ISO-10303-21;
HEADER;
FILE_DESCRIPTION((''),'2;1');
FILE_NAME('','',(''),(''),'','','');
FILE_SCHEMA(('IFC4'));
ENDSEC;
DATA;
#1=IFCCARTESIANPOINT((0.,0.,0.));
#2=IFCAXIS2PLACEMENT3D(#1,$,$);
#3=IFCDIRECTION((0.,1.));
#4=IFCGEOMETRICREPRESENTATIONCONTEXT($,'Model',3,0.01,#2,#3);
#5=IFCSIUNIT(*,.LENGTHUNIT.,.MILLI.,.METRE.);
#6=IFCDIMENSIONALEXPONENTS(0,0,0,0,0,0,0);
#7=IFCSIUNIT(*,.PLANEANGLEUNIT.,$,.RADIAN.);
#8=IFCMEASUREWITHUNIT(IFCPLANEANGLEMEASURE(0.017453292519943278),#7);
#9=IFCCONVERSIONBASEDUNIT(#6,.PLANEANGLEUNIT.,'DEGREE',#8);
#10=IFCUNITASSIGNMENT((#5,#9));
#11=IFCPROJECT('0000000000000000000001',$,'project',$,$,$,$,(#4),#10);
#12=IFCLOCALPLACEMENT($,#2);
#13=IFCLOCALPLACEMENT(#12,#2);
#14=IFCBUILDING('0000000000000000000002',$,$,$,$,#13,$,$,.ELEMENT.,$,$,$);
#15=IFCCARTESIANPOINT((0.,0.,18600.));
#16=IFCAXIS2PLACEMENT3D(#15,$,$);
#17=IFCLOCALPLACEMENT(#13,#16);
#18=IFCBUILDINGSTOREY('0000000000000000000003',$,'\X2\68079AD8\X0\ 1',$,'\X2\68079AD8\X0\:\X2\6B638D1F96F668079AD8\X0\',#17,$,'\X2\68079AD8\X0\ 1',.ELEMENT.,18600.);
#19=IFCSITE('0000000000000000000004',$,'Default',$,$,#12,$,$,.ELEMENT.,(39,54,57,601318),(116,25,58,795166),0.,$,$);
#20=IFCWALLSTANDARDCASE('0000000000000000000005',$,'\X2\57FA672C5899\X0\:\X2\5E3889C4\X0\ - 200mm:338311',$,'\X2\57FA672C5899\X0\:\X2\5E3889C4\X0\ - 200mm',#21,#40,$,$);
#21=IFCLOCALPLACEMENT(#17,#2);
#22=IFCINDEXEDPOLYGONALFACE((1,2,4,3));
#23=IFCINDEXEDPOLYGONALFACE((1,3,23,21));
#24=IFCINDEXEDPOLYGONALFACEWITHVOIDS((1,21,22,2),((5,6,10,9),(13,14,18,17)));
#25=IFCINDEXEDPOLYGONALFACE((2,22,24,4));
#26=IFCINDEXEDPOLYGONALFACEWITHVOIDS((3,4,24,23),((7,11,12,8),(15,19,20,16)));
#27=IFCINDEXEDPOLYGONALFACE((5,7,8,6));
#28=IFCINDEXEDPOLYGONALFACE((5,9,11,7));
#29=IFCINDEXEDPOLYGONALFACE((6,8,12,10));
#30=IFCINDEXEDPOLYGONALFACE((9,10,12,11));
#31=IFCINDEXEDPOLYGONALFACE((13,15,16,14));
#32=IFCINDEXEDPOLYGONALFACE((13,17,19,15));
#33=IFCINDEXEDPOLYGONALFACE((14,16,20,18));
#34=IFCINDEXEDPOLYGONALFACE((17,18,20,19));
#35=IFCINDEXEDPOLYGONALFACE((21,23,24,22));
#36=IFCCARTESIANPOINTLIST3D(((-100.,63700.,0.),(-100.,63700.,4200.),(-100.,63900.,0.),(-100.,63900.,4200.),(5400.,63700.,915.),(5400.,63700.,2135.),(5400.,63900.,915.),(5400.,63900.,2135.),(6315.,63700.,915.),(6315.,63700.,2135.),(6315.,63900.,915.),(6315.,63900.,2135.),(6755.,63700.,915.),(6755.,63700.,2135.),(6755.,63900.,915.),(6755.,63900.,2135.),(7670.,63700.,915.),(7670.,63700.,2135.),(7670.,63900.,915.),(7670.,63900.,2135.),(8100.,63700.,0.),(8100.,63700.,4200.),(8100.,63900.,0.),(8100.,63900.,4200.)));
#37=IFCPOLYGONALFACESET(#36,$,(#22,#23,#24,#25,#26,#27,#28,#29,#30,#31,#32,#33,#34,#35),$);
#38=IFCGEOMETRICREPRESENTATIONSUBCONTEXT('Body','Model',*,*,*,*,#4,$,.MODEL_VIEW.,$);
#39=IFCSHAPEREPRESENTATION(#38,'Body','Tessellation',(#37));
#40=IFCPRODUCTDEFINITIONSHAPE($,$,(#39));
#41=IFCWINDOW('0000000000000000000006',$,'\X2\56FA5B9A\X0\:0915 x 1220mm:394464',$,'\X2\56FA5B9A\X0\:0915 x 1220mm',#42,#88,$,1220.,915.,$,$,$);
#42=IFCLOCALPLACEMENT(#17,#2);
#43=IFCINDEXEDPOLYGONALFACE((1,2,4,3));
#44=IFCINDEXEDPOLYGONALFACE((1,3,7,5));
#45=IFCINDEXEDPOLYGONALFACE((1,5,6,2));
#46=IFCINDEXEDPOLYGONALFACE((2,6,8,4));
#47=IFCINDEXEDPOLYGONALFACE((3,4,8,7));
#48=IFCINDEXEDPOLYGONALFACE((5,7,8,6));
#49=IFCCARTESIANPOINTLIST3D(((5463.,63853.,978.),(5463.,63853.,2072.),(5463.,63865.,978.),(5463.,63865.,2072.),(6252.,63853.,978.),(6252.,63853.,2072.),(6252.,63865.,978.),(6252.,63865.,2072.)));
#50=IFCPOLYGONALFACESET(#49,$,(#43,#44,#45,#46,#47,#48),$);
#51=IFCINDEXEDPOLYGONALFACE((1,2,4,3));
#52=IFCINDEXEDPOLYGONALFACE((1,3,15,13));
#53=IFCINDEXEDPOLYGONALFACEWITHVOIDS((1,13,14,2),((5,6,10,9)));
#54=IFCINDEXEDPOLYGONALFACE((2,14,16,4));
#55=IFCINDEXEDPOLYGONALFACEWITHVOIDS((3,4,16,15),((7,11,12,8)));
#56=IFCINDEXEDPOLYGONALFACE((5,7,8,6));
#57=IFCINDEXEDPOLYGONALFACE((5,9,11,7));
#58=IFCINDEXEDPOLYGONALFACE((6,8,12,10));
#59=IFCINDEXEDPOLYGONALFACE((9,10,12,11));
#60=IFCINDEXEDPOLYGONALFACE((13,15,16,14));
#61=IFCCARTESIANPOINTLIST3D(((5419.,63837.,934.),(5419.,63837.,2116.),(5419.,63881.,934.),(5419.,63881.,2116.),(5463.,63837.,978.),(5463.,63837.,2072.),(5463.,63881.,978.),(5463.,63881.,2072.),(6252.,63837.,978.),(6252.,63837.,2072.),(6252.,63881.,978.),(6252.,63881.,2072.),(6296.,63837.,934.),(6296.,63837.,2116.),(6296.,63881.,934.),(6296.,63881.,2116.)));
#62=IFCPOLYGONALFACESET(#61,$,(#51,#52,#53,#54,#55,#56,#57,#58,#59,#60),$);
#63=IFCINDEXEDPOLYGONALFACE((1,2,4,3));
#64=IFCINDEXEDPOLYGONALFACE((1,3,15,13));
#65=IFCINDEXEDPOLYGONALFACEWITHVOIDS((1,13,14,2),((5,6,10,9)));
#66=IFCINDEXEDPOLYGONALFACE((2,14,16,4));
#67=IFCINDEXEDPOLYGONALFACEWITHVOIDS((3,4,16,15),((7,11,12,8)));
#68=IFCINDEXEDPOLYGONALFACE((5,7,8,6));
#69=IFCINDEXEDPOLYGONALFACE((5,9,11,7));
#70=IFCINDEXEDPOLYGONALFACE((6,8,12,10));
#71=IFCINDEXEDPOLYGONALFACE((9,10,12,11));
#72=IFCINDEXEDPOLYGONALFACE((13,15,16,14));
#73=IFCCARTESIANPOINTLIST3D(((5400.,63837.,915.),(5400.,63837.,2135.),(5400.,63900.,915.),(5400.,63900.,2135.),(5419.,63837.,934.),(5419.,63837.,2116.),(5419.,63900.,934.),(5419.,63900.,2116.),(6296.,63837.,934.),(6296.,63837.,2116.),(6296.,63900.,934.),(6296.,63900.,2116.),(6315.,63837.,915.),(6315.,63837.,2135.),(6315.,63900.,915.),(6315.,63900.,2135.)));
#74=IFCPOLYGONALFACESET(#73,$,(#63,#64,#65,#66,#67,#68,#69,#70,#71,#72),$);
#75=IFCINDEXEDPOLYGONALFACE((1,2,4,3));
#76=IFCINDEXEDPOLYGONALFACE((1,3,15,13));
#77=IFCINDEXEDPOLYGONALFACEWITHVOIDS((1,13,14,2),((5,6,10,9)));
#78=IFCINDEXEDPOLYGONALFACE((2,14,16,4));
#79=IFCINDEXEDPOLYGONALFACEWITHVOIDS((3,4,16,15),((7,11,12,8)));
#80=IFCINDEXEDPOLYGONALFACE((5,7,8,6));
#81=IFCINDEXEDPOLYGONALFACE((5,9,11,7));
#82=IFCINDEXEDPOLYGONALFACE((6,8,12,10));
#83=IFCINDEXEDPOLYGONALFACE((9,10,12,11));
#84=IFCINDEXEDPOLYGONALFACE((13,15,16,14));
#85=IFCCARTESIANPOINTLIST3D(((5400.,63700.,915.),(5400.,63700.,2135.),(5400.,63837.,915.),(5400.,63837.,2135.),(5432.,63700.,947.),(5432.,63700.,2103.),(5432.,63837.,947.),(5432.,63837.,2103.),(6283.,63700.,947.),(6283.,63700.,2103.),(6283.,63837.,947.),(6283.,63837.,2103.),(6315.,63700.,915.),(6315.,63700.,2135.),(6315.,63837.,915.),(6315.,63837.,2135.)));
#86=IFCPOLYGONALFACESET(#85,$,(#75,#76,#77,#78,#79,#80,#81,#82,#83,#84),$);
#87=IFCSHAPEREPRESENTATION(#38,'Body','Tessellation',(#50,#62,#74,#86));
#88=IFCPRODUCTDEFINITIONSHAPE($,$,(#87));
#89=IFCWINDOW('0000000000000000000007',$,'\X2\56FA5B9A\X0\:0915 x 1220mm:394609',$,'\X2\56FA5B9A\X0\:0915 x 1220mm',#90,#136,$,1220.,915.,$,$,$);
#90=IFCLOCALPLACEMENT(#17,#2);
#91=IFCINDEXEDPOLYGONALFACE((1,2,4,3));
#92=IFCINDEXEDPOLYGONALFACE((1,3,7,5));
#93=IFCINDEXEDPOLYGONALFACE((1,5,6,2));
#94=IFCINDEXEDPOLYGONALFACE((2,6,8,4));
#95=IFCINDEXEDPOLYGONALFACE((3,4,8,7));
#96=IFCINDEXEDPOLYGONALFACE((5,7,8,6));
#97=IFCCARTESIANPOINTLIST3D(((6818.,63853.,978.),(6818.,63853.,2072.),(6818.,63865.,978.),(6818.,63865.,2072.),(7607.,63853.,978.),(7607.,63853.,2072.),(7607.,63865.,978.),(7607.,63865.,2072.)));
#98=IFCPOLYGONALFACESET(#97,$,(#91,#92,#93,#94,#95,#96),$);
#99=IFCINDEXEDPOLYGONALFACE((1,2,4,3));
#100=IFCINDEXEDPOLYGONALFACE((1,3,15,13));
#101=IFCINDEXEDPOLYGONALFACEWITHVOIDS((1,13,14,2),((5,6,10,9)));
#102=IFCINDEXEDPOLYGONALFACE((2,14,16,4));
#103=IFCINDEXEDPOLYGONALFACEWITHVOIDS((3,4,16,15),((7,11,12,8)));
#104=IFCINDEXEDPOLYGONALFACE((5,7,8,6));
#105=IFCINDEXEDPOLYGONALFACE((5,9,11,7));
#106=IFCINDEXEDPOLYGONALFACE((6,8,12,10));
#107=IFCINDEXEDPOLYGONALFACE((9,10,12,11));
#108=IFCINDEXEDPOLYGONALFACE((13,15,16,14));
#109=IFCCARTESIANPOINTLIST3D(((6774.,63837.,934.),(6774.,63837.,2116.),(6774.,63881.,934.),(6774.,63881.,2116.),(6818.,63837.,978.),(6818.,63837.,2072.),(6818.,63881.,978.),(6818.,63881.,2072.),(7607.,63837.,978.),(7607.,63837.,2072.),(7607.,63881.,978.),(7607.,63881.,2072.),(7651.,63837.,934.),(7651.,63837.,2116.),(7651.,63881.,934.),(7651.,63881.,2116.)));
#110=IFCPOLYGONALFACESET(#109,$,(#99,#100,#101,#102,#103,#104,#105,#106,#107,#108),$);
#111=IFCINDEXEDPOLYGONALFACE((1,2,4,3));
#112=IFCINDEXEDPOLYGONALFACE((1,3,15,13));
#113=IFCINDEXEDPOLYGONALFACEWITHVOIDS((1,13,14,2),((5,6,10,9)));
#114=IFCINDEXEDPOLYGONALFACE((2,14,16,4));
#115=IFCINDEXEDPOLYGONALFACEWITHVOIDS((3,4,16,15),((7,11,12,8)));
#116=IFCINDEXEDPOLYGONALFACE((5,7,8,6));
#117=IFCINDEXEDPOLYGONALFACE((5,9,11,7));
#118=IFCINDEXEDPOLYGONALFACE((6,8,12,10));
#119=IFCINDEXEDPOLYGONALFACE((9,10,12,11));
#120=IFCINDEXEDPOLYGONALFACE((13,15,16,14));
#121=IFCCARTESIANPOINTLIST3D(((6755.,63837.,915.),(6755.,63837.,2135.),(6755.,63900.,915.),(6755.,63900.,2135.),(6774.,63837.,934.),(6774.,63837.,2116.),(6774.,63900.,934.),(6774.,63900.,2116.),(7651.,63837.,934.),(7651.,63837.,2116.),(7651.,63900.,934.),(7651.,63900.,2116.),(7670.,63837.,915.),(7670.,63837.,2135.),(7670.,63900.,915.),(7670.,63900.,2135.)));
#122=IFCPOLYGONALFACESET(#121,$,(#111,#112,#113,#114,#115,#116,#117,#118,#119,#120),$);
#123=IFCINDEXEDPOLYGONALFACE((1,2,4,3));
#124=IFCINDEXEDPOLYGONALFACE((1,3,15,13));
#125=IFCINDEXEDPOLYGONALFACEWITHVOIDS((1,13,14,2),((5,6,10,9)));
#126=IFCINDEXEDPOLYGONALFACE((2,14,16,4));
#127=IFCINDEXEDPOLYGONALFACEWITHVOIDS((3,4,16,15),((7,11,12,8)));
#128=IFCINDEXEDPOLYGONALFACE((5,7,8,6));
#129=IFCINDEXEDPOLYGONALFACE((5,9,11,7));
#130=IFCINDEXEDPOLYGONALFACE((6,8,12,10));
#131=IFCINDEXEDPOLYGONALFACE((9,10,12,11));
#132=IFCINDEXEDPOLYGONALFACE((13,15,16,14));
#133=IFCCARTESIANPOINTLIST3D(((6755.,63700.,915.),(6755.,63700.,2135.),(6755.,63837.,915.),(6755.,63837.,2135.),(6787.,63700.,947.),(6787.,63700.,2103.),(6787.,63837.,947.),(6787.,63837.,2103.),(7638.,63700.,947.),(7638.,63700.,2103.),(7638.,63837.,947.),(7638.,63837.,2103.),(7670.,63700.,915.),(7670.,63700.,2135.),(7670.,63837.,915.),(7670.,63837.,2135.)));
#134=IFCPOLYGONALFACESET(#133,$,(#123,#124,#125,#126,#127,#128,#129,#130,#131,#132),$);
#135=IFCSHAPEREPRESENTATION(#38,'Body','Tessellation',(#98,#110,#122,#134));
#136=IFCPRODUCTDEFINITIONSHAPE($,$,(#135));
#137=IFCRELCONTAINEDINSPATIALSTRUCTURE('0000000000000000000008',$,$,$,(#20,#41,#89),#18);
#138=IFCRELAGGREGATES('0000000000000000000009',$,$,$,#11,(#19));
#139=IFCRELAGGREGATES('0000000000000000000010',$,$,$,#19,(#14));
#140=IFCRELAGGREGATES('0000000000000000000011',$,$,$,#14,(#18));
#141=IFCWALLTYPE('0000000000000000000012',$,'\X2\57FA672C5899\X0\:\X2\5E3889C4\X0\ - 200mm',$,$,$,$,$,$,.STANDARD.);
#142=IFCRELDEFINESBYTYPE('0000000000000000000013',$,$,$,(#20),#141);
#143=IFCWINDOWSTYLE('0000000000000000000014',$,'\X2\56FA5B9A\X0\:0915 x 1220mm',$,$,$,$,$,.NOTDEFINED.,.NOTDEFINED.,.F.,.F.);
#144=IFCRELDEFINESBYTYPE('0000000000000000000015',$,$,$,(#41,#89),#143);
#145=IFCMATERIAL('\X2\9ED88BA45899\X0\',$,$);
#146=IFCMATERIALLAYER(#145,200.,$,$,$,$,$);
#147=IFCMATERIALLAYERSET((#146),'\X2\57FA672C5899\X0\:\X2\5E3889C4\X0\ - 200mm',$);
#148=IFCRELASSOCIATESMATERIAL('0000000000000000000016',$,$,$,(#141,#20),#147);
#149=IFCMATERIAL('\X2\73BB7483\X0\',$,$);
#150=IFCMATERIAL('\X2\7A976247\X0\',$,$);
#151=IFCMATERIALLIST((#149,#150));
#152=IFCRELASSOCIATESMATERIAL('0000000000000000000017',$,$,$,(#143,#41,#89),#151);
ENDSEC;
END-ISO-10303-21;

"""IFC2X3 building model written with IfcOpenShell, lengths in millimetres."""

from ifc_helpers import new_model, entity, si_unit, converted_unit, direction, frame, frame_2d, origin, place, context, subcontext, project, spatial, polyline, rectangle, outline, extrude, source, transform, mapped, material, material_list, layer, layer_set, layer_usage, type_object, type_shapes, element, fill, save


model = new_model("IFC2X3")

# Units and contexts
model_context = context("Model", 3, precision=0.01, world=origin(), true_north=direction((0.0, 1.0)))
body_context = subcontext(model_context, "Body", "Model", "MODEL_VIEW")
ifc_project = project(units=[si_unit("LENGTHUNIT", "METRE", prefix="MILLI"), converted_unit("PLANEANGLEUNIT", "DEGREE", entity("IfcPlaneAngleMeasure", 0.017453292519943278), si_unit("PLANEANGLEUNIT", "RADIAN"), dimensions=[0, 0, 0, 0, 0, 0, 0])], contexts=[model_context])

# Site, building, storey
site_placement = place(None, origin())
site = spatial("IfcSite", under=ifc_project, at=site_placement, Name="Default", CompositionType="ELEMENT", RefLatitude=(39, 54, 57, 601318), RefLongitude=(116, 25, 58, 795166), RefElevation=0.0)
building_placement = place(site_placement, origin())
building = spatial("IfcBuilding", under=site, at=building_placement, CompositionType="ELEMENT")
storey_placement = place(building_placement, frame((0.0, 0.0, 18600.0)))
storey = spatial("IfcBuildingStorey", under=building, at=storey_placement, Name="标高 1", ObjectType="标高:正负零标高", LongName="标高 1", CompositionType="ELEMENT", Elevation=18600.0)

# Wall, openings, windows
ifc_material_1 = material(Name="默认墙")
ifc_layer = layer(ifc_material_1, 200.0)
ifc_layer_set = layer_set([ifc_layer], Name="基本墙:常规 - 200mm")
ifc_layer_usage_1 = layer_usage(ifc_layer_set, "AXIS2", "NEGATIVE", 100.0)
wall_type = type_object("IfcWallType", Name="基本墙:常规 - 200mm", PredefinedType="STANDARD", material=ifc_layer_set)
wall_1_placement = place(storey_placement, frame((-100.0, 63800.0, 0.0)))
wall_1 = element("IfcWallStandardCase", 1, at=wall_1_placement, inside=storey, type_object=wall_type, material=ifc_layer_usage_1, Name="基本墙:常规 - 200mm:338311", ObjectType="基本墙:常规 - 200mm", context=body_context, shape_type="SweptSolid", body=[
    extrude(rectangle(XDim=8200.0, YDim=200.0, at=frame_2d((4100.0, 0.0), x_axis=(-1.0, 0.0))), origin(), (0.0, 0.0, 1.0), 4200.0),
])
opening_1_placement = place(wall_1_placement, frame((5500.0, -100.0, 915.0)))
opening_1 = element("IfcOpeningElement", 2, at=opening_1_placement, cuts=wall_1, ObjectType="Opening", context=body_context, shape_type="SweptSolid", body=[
    extrude(rectangle(XDim=1220.0, YDim=915.0, at=frame_2d((610.0, 457.5), x_axis=(1.0, 0.0))), frame((0.0, 0.0, 0.0), z_axis=(0.0, 1.0, 0.0), x_axis=(0.0, 0.0, 1.0)), (0.0, 0.0, 1.0), 200.0),
])
opening_2_placement = place(wall_1_placement, frame((6855.0, -100.0, 915.0)))
opening_2 = element("IfcOpeningElement", 3, at=opening_2_placement, cuts=wall_1, ObjectType="Opening", context=body_context, shape_type="SweptSolid", body=[
    extrude(rectangle(XDim=1220.0, YDim=915.0, at=frame_2d((610.0, 457.5), x_axis=(1.0, 0.0))), frame((0.0, 0.0, 0.0), z_axis=(0.0, 1.0, 0.0), x_axis=(0.0, 0.0, 1.0)), (0.0, 0.0, 1.0), 200.0),
])
ifc_material_2 = material(Name="玻璃")
ifc_material_3 = material(Name="窗扇")
ifc_material_list_1 = material_list([ifc_material_2, ifc_material_3])
window_style = type_object("IfcWindowStyle", Name="固定:0915 x 1220mm", ConstructionType="NOTDEFINED", OperationType="NOTDEFINED", ParameterTakesPrecedence=False, Sizeable=False, material=ifc_material_list_1)
shared_shape_1 = source(origin(), body_context, "Body", "SweptSolid", [
    extrude(rectangle(XDim=12.0, YDim=789.0, at=frame_2d((0.0, 0.0), x_axis=(1.0, 0.0))), frame((457.5, 159.0, 63.0), z_axis=(0.0, 0.0, 1.0), x_axis=(0.0, -1.0, 0.0)), (0.0, 0.0, 1.0), 1094.0),
    extrude(outline(polyline([(-438.5, -591.0), (438.5, -591.0), (438.5, 591.0), (-438.5, 591.0), (-438.5, -591.0)]), holes=[polyline([(-394.5, -547.0), (-394.5, 547.0), (394.5, 547.0), (394.5, -547.0), (-394.5, -547.0)])]), frame((457.5, 137.0, 610.0), z_axis=(0.0, 1.0, 0.0), x_axis=(1.0, 0.0, 0.0)), (0.0, 0.0, 1.0), 44.0),
    extrude(outline(polyline([(-457.5, -610.0), (457.5, -610.0), (457.5, 610.0), (-457.5, 610.0), (-457.5, -610.0)]), holes=[polyline([(-438.5, -591.0), (-438.5, 591.0), (438.5, 591.0), (438.5, -591.0), (-438.5, -591.0)])]), frame((457.5, 137.0, 610.0), z_axis=(0.0, 1.0, 0.0), x_axis=(1.0, 0.0, 0.0)), (0.0, 0.0, 1.0), 63.0),
    extrude(outline(polyline([(-457.5, -610.0), (457.5, -610.0), (457.5, 610.0), (-457.5, 610.0), (-457.5, -610.0)]), holes=[polyline([(-425.5, -578.0), (-425.5, 578.0), (425.5, 578.0), (425.5, -578.0), (-425.5, -578.0)])]), frame((457.5, 0.0, 610.0), z_axis=(0.0, 1.0, 0.0), x_axis=(1.0, 0.0, 0.0)), (0.0, 0.0, 1.0), 137.0),
])
type_shapes(window_style, [shared_shape_1])
window_1_placement = place(opening_1_placement, origin())
window_1 = element("IfcWindow", 4, at=window_1_placement, inside=storey, type_object=window_style, material=ifc_material_list_1, Name="固定:0915 x 1220mm:394464", ObjectType="固定:0915 x 1220mm", OverallHeight=1220.0, OverallWidth=915.0, context=body_context, shape_type="MappedRepresentation", body=[
    mapped(shared_shape_1, transform((0.0, 0.0, 0.0), scale=1.0)),
])
fill(opening_1, window_1)
window_2_placement = place(opening_2_placement, origin())
window_2 = element("IfcWindow", 5, at=window_2_placement, inside=storey, type_object=window_style, material=ifc_material_list_1, Name="固定:0915 x 1220mm:394609", ObjectType="固定:0915 x 1220mm", OverallHeight=1220.0, OverallWidth=915.0, context=body_context, shape_type="MappedRepresentation", body=[
    mapped(shared_shape_1, transform((0.0, 0.0, 0.0), scale=1.0)),
])
fill(opening_2, window_2)

save(model, "model.ifc")
